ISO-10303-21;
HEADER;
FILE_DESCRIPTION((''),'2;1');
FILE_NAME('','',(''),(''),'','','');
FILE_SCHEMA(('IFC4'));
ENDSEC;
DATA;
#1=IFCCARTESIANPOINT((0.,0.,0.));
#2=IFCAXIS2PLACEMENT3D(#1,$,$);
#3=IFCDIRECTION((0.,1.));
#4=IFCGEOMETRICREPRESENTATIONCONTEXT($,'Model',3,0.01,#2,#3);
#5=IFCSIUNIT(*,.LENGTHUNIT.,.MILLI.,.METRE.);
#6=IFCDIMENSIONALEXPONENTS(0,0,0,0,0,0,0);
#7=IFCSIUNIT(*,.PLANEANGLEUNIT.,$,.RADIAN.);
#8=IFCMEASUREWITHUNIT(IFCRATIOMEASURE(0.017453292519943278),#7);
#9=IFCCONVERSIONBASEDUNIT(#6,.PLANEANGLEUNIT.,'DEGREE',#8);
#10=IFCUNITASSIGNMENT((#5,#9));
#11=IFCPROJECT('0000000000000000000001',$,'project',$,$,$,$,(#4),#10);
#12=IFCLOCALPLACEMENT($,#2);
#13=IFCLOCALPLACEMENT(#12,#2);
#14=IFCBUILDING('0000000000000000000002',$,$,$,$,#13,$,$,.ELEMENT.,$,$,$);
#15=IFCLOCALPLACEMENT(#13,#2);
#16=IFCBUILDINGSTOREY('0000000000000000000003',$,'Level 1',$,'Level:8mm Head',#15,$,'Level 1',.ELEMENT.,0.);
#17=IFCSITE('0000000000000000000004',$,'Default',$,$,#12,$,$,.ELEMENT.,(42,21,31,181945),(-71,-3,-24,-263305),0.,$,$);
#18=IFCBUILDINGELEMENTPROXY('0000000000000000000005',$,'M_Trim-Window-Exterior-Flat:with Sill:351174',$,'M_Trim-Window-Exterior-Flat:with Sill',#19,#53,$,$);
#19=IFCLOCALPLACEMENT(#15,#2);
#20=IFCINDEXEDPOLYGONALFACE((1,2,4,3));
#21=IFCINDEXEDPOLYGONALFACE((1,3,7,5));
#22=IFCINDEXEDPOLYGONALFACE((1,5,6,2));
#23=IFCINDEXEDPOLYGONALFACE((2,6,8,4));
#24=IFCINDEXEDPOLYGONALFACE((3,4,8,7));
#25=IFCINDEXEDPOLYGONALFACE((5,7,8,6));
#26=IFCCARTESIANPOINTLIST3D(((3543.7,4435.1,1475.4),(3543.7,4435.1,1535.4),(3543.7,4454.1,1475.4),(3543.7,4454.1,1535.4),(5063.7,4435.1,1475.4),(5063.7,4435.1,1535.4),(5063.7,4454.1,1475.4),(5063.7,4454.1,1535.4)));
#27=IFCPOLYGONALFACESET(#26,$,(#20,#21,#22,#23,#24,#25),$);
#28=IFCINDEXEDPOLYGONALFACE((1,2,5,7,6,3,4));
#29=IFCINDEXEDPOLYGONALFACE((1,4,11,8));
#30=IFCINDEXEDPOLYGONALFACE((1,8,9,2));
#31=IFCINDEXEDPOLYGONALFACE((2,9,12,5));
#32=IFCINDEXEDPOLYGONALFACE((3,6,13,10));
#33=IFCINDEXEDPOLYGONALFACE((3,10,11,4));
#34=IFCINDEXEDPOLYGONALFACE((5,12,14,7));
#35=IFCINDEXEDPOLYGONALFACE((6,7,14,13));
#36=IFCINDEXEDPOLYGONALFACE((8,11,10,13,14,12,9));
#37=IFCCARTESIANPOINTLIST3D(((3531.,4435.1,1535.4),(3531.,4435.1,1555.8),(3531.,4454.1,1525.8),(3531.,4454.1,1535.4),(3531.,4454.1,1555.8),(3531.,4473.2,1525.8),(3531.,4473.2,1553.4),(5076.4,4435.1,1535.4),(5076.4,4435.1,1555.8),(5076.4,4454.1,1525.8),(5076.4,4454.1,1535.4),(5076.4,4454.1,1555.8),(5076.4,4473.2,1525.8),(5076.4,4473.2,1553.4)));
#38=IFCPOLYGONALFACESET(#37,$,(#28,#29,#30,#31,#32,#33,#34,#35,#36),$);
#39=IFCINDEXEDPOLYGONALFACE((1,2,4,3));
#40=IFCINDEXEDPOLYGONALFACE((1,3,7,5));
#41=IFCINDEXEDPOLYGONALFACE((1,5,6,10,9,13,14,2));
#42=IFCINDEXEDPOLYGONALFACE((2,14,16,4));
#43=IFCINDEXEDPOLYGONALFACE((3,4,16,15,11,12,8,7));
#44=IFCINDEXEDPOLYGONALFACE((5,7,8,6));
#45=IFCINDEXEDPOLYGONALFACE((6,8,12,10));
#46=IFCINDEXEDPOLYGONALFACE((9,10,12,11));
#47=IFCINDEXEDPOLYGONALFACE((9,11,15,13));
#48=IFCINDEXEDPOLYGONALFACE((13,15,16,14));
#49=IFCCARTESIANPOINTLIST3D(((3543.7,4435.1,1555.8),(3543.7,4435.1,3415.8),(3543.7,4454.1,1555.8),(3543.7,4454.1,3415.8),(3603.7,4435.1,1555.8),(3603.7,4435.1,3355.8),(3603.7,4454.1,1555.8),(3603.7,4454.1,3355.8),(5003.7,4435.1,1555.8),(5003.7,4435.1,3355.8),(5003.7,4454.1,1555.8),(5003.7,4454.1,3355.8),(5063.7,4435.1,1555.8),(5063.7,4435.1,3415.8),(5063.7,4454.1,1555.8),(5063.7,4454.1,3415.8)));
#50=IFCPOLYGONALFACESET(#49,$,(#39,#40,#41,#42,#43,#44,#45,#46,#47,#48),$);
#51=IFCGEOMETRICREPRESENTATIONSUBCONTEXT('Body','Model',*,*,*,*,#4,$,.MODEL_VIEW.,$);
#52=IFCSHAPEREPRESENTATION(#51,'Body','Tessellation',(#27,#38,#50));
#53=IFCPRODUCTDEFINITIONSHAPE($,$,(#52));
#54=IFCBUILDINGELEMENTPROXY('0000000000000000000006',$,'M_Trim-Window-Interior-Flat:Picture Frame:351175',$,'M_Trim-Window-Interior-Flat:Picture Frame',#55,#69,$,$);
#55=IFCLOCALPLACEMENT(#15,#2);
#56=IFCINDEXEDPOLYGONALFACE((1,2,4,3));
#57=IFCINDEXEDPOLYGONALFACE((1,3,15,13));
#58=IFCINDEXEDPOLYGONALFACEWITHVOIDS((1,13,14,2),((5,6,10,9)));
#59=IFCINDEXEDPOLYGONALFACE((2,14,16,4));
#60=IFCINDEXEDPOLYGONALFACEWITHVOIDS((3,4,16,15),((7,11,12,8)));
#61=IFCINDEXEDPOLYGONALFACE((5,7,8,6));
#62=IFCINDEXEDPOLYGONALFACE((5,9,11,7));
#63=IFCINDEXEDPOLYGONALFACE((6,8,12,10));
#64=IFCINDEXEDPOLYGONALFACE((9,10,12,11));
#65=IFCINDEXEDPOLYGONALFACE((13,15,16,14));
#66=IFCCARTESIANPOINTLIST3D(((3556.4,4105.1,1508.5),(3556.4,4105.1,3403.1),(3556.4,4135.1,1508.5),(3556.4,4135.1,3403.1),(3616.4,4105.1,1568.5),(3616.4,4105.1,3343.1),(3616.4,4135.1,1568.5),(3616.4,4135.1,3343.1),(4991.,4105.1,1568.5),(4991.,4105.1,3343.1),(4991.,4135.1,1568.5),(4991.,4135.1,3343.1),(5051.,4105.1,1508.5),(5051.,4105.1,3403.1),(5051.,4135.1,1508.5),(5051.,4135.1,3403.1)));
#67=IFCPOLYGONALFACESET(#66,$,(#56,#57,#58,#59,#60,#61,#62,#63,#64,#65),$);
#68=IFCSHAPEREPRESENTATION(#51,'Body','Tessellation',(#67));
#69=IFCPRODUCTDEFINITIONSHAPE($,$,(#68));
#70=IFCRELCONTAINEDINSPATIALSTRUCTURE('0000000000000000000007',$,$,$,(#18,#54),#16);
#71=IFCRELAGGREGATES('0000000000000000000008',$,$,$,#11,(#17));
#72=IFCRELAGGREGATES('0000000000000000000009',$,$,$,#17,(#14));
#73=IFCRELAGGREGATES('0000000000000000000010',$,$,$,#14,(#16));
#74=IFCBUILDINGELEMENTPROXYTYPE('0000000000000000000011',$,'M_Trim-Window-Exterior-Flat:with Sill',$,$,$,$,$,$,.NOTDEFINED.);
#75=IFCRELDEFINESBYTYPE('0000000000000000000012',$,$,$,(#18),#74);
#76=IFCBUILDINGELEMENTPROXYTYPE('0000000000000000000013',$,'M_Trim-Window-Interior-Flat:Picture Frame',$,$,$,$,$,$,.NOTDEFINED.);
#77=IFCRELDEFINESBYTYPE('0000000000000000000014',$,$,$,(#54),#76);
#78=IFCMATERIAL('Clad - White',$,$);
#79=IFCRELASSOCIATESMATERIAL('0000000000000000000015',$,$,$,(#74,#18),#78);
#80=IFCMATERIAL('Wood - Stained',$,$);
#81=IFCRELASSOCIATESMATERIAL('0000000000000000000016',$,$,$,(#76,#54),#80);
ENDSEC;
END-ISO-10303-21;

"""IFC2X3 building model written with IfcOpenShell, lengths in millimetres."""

from ifc_helpers import new_model, entity, si_unit, converted_unit, direction, frame, frame_2d, origin, place, context, subcontext, project, spatial, polyline, rectangle, outline, extrude, source, transform, mapped, material, type_object, type_shapes, element, save


model = new_model("IFC2X3")

# Units and contexts
model_context = context("Model", 3, precision=0.01, world=origin(), true_north=direction((0.0, 1.0)))
body_context = subcontext(model_context, "Body", "Model", "MODEL_VIEW")
ifc_project = project(units=[si_unit("LENGTHUNIT", "METRE", prefix="MILLI"), converted_unit("PLANEANGLEUNIT", "DEGREE", entity("IfcRatioMeasure", 0.017453292519943278), si_unit("PLANEANGLEUNIT", "RADIAN"), dimensions=[0, 0, 0, 0, 0, 0, 0])], contexts=[model_context])

# Site, building, storey
site_placement = place(None, origin())
site = spatial("IfcSite", under=ifc_project, at=site_placement, Name="Default", CompositionType="ELEMENT", RefLatitude=(42, 21, 31, 181945), RefLongitude=(-71, -3, -24, -263305), RefElevation=0.0)
building_placement = place(site_placement, origin())
building = spatial("IfcBuilding", under=site, at=building_placement, CompositionType="ELEMENT")
storey_placement = place(building_placement, origin())
storey = spatial("IfcBuildingStorey", under=building, at=storey_placement, Name="Level 1", ObjectType="Level:8mm Head", LongName="Level 1", CompositionType="ELEMENT", Elevation=0.0)

# Building element proxies
ifc_material_1 = material(Name="Clad - White")
ifc_material_2 = material(Name="Wood - Stained")
building_element_proxy_type_1 = type_object("IfcBuildingElementProxyType", Name="M_Trim-Window-Exterior-Flat:with Sill", PredefinedType="NOTDEFINED", material=ifc_material_1)
shared_shape_1 = source(origin(), body_context, "Body", "SweptSolid", [
    extrude(rectangle(XDim=1520.0, YDim=60.0, at=frame_2d((0.0, 0.0), x_axis=(1.0, 0.0))), frame((0.0, -1850.4, 0.0), z_axis=(0.0, 0.0, 1.0), x_axis=(-1.0, 0.0, 0.0)), (0.0, 0.0, 1.0), 19.0),
    extrude(outline(polyline([(-19.0, -15.2), (0.0, -15.2), (0.0, -5.7), (19.0, -5.7), (19.0, 14.8), (0.0, 14.8), (-19.0, 12.3), (-19.0, -15.2)])), frame((-772.7, -1814.8, 19.0), z_axis=(1.0, 0.0, 0.0), x_axis=(0.0, 0.0, -1.0)), (0.0, 0.0, 1.0), 1545.4),
    extrude(outline(polyline([(-945.0, -760.0), (915.0, -760.0), (915.0, -700.0), (-885.0, -700.0), (-885.0, 700.0), (915.0, 700.0), (915.0, 760.0), (-945.0, 760.0), (-945.0, -760.0)])), frame((0.0, -885.0, 0.0), z_axis=(0.0, 0.0, 1.0), x_axis=(0.0, -1.0, 0.0)), (0.0, 0.0, 1.0), 19.0),
])
type_shapes(building_element_proxy_type_1, [shared_shape_1])
proxy_1_placement = place(storey_placement, frame((4303.7, 4435.1, 3355.8), z_axis=(0.0, 1.0, 0.0), x_axis=(-1.0, 0.0, 0.0)))
element("IfcBuildingElementProxy", 1, at=proxy_1_placement, inside=storey, type_object=building_element_proxy_type_1, material=ifc_material_1, Name="M_Trim-Window-Exterior-Flat:with Sill:351174", ObjectType="M_Trim-Window-Exterior-Flat:with Sill", context=body_context, shape_type="MappedRepresentation", body=[
    mapped(shared_shape_1, transform((0.0, 0.0, 0.0), scale=1.0)),
])
building_element_proxy_type_2 = type_object("IfcBuildingElementProxyType", Name="M_Trim-Window-Interior-Flat:Picture Frame", PredefinedType="NOTDEFINED", material=ifc_material_2)
shared_shape_2 = source(origin(), body_context, "Body", "SweptSolid", [
    extrude(outline(polyline([(-747.3, -947.3), (747.3, -947.3), (747.3, 947.3), (-747.3, 947.3), (-747.3, -947.3)]), holes=[polyline([(-687.3, -887.3), (-687.3, 887.3), (687.3, 887.3), (687.3, -887.3), (-687.3, -887.3)])]), frame((0.0, -900.0, 0.0), z_axis=(0.0, 0.0, 1.0), x_axis=(-1.0, 0.0, 0.0)), (0.0, 0.0, 1.0), 30.0),
])
type_shapes(building_element_proxy_type_2, [shared_shape_2])
proxy_2_placement = place(storey_placement, frame((4303.7, 4135.1, 3355.8), z_axis=(0.0, -1.0, 0.0), x_axis=(1.0, 0.0, 0.0)))
element("IfcBuildingElementProxy", 2, at=proxy_2_placement, inside=storey, type_object=building_element_proxy_type_2, material=ifc_material_2, Name="M_Trim-Window-Interior-Flat:Picture Frame:351175", ObjectType="M_Trim-Window-Interior-Flat:Picture Frame", context=body_context, shape_type="MappedRepresentation", body=[
    mapped(shared_shape_2, transform((0.0, 0.0, 0.0), scale=1.0)),
])

save(model, "model.ifc")
